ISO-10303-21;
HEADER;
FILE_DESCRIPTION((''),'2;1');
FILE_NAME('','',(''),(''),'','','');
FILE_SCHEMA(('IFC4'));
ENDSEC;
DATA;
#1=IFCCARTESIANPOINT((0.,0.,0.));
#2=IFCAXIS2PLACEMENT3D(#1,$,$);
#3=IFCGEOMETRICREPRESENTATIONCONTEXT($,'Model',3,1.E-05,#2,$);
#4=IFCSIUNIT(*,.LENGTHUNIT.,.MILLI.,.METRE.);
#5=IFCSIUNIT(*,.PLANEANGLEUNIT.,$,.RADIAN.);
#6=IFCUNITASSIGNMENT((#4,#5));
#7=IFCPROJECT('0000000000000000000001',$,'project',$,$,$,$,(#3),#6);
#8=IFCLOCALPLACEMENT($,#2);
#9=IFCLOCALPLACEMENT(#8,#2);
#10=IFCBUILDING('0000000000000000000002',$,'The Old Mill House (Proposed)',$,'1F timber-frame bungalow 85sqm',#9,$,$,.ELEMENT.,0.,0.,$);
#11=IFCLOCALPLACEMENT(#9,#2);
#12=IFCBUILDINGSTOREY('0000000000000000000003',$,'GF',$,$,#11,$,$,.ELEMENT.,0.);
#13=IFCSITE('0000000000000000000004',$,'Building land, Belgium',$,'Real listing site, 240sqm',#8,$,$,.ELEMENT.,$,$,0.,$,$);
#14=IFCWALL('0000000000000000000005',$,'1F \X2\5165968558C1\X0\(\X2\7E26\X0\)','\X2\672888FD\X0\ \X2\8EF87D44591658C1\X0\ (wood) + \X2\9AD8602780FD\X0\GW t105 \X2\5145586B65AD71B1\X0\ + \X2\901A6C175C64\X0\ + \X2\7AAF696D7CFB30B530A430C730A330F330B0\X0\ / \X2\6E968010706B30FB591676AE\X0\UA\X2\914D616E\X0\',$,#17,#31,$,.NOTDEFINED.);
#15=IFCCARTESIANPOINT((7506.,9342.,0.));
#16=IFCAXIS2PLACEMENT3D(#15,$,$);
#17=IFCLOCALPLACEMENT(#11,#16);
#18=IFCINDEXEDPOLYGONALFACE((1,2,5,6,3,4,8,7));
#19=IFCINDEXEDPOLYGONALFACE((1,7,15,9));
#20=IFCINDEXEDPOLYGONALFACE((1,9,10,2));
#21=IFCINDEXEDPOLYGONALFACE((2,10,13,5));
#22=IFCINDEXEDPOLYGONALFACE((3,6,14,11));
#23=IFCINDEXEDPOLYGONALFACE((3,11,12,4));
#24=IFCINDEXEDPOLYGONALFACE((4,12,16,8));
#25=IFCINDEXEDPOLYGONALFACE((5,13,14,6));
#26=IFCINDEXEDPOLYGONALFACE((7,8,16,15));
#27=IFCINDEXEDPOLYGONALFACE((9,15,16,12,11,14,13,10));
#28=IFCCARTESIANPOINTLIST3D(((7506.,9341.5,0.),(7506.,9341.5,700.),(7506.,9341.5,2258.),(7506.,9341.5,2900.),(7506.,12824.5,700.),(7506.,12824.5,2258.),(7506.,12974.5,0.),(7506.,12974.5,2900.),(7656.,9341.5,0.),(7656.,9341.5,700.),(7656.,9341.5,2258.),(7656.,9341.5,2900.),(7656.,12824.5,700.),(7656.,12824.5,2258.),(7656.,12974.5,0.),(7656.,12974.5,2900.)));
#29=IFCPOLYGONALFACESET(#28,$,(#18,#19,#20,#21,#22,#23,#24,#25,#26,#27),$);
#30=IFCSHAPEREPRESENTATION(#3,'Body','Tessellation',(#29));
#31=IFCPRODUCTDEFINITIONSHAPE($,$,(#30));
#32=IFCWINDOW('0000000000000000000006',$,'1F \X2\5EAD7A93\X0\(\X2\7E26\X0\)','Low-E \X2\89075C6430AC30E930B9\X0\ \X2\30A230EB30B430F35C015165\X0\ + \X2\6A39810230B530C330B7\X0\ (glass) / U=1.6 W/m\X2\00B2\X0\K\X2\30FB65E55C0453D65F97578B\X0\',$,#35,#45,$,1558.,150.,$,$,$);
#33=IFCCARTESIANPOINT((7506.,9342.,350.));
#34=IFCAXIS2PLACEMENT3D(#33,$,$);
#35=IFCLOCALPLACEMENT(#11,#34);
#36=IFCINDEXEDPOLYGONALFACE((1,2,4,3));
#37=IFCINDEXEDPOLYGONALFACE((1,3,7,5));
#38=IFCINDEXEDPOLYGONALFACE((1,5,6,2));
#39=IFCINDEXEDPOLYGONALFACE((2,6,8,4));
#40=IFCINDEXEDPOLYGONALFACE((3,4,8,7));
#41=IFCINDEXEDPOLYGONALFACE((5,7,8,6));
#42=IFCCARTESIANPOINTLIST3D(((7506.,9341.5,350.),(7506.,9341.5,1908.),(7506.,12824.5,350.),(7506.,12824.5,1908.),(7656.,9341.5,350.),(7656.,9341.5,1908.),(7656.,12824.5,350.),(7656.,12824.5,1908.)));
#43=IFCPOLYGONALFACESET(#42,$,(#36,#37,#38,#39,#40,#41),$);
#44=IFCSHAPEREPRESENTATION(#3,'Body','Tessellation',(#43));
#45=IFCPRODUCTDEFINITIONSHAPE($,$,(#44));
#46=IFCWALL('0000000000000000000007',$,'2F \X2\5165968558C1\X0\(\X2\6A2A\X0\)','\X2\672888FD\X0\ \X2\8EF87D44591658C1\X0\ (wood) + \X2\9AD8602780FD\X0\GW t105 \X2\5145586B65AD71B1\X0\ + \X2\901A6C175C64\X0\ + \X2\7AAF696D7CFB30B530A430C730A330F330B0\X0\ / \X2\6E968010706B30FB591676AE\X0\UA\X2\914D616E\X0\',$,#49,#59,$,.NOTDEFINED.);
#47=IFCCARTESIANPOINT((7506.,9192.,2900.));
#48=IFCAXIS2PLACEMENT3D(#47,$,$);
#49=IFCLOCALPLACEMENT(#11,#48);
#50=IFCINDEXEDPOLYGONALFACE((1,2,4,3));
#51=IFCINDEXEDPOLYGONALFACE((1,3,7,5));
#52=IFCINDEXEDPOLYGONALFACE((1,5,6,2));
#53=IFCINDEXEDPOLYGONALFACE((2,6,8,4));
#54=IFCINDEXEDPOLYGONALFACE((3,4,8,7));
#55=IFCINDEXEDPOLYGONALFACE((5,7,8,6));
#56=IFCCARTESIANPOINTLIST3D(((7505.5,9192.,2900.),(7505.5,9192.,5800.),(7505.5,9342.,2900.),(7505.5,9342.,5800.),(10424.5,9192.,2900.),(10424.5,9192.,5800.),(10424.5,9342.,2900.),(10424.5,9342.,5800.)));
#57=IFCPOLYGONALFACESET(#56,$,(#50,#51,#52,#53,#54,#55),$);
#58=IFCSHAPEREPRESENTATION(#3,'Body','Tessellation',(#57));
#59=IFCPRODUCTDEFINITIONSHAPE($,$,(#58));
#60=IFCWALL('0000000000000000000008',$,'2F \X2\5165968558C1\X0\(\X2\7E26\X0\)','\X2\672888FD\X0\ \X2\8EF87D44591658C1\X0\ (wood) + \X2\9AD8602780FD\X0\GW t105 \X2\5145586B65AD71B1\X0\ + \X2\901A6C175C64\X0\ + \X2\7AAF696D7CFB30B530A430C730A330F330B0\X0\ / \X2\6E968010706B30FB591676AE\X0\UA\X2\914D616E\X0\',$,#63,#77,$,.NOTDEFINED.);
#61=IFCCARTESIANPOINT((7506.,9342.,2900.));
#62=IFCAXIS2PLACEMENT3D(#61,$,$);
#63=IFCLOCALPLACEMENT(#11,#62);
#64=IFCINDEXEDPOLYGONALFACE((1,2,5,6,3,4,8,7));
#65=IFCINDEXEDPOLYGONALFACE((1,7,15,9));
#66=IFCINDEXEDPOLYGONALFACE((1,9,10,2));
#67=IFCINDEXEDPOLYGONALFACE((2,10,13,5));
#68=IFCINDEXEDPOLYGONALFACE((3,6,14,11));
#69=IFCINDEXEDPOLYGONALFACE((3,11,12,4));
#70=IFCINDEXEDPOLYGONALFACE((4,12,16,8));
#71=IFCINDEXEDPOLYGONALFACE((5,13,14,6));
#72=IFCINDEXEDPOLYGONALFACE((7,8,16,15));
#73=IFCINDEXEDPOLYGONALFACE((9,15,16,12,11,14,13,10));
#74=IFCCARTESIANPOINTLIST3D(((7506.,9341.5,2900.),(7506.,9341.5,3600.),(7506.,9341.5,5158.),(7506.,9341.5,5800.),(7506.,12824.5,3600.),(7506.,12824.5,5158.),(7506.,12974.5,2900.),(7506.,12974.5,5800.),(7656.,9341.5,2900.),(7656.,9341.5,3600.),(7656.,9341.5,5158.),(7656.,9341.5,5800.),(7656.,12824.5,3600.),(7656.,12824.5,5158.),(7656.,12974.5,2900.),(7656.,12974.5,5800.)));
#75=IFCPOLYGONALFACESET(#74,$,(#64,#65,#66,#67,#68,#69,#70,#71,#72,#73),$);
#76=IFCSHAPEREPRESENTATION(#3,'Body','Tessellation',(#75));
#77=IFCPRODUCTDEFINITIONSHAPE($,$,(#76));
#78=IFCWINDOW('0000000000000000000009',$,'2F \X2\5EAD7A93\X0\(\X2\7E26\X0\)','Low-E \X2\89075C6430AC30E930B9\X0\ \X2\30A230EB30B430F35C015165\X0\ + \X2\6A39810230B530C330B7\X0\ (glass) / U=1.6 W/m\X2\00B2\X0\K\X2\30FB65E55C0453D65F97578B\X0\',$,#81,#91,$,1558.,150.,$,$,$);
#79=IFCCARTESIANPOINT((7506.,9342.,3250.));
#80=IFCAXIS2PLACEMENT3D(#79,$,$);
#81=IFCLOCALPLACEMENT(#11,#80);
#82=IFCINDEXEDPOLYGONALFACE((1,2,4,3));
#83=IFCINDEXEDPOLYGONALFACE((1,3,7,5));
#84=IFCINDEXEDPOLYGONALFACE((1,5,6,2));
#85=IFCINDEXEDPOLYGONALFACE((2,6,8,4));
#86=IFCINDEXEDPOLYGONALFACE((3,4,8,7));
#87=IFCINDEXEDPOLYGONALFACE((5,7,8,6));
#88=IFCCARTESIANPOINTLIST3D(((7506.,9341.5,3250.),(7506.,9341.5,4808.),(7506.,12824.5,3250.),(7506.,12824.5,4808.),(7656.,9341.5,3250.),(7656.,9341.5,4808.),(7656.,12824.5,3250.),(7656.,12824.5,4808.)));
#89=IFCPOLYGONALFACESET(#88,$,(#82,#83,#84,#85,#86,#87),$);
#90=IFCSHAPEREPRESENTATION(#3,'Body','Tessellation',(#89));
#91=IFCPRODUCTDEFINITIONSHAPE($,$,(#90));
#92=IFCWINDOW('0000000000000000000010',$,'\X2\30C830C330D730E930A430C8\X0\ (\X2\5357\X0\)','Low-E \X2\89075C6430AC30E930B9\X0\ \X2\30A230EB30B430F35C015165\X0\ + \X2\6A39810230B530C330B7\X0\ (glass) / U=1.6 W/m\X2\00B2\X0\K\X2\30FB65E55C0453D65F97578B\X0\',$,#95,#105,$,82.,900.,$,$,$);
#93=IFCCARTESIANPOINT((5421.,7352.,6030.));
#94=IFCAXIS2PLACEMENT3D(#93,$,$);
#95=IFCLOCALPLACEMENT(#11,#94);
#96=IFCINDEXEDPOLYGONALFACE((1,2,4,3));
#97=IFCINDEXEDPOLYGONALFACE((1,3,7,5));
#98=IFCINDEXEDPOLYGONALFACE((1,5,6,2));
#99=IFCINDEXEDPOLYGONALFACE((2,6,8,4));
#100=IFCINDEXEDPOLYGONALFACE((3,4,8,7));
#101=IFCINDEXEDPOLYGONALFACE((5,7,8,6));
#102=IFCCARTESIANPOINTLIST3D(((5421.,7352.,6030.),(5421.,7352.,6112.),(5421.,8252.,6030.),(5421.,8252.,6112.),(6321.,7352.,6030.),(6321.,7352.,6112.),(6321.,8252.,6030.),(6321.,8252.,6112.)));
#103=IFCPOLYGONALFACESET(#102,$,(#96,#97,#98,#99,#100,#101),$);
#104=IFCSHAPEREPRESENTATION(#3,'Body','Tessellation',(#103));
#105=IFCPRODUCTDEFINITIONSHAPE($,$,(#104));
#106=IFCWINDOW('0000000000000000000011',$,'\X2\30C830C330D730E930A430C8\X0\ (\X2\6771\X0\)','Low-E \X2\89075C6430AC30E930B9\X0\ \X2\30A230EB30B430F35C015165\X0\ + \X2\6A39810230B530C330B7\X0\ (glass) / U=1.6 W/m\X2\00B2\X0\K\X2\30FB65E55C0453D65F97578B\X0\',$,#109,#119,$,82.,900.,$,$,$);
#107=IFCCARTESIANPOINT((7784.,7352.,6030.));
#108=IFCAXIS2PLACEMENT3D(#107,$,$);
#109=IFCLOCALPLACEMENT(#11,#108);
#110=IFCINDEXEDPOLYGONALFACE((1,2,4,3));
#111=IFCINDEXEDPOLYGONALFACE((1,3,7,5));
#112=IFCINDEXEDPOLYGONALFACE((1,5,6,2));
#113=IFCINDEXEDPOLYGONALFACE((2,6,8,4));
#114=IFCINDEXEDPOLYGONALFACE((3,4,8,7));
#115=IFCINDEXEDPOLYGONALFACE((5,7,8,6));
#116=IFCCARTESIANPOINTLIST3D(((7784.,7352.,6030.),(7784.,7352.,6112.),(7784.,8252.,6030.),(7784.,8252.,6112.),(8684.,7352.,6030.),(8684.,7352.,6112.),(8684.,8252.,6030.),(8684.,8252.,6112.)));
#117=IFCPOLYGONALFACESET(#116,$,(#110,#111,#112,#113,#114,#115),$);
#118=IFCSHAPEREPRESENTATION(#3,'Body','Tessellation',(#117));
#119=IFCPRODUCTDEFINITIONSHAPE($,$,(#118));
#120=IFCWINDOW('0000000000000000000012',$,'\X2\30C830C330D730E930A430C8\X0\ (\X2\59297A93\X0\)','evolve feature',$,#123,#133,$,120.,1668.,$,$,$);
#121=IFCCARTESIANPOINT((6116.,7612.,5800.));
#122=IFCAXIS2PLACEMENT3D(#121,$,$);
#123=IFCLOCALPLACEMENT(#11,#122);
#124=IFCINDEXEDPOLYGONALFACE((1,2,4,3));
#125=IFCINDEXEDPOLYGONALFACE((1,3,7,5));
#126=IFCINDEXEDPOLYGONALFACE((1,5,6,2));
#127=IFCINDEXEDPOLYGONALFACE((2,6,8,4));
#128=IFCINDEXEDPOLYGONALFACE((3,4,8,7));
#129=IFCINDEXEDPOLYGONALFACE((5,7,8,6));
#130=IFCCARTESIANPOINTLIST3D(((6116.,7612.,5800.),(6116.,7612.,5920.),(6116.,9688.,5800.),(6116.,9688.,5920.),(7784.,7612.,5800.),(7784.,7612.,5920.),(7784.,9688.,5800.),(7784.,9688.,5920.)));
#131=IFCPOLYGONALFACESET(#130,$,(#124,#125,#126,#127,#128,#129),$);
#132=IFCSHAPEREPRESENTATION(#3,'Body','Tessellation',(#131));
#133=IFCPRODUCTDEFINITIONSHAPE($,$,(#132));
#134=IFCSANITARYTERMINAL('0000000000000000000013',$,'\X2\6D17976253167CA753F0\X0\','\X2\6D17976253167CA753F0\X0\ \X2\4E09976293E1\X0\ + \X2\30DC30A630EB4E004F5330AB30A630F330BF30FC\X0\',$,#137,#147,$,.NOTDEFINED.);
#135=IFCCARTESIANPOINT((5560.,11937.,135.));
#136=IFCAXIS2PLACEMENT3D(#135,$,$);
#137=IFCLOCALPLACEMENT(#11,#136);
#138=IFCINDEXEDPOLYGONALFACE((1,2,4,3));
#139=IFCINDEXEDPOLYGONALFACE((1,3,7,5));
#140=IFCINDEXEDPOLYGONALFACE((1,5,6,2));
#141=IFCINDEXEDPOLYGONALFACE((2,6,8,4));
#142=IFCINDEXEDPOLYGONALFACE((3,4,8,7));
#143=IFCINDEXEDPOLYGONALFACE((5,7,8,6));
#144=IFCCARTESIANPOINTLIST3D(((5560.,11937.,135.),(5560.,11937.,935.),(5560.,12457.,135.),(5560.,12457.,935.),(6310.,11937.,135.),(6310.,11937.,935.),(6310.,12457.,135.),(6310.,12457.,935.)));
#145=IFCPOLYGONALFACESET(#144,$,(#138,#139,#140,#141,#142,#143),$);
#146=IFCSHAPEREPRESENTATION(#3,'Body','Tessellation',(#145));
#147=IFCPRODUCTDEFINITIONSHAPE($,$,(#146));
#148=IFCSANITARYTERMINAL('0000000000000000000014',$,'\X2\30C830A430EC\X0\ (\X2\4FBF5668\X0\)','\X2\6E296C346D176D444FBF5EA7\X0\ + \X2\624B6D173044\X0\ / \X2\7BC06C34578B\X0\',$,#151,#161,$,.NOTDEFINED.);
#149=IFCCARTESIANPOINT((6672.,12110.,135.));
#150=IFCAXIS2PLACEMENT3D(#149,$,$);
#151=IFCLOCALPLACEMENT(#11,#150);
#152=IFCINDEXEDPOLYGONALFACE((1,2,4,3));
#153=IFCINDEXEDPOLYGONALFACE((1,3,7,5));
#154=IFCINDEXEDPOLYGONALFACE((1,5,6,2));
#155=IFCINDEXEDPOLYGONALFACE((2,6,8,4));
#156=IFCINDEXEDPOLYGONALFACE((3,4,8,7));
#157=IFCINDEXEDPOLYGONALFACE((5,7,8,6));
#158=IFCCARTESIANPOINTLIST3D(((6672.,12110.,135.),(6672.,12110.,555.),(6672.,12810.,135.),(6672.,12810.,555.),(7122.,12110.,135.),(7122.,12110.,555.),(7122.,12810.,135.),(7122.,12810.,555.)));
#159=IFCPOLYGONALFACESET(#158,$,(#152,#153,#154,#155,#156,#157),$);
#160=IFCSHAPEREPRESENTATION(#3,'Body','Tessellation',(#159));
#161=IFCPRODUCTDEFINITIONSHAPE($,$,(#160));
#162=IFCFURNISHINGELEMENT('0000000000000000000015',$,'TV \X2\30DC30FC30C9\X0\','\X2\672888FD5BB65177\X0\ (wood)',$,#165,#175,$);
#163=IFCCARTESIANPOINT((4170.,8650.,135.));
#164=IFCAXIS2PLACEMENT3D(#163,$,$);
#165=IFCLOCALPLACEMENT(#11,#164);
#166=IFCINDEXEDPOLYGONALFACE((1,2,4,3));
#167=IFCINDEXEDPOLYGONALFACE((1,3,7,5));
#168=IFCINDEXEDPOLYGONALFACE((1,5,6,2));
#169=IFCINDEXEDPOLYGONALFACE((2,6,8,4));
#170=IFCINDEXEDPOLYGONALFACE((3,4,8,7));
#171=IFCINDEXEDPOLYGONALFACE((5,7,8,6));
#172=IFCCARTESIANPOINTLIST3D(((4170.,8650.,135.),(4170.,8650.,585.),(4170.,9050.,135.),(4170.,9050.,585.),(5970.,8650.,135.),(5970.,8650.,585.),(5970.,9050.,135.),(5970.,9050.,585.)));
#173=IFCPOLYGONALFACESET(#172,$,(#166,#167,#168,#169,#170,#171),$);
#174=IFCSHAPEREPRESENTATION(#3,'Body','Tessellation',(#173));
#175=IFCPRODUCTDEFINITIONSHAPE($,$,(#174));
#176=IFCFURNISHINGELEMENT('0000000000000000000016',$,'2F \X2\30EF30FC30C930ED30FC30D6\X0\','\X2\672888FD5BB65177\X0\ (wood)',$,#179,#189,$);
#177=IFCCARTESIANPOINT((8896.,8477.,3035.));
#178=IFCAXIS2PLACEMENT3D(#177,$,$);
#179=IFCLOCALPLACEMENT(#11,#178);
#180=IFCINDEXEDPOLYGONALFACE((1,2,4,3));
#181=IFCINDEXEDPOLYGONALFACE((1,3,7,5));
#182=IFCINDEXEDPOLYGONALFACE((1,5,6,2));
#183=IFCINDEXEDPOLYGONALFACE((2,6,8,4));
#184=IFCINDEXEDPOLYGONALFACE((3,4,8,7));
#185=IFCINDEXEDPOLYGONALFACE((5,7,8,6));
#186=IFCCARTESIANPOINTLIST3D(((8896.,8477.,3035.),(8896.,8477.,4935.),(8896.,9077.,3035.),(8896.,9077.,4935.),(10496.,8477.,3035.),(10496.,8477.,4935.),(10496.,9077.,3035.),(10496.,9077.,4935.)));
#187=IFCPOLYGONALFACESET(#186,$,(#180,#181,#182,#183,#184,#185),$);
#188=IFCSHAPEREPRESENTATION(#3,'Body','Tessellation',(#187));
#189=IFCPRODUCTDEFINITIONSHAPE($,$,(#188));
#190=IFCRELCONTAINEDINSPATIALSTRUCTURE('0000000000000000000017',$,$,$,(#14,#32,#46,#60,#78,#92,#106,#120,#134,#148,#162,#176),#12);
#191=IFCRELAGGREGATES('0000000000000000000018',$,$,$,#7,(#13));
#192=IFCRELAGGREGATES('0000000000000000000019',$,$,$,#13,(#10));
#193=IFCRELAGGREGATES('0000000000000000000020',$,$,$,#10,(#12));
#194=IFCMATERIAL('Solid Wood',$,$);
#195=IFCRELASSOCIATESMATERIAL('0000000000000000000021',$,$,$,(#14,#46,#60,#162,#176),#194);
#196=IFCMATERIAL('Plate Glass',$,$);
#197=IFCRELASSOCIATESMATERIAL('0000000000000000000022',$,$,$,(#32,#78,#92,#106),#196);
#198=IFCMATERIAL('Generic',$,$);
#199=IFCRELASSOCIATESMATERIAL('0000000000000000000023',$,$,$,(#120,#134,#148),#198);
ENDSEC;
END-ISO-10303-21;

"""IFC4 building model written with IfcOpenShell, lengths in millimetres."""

from ifc_helpers import new_model, si_unit, frame, frame_2d, origin, place, context, project, spatial, rectangle, extrude, material, element, fill, save


model = new_model("IFC4")

# Units and contexts
model_context = context("Model", 3, precision=1e-05, world=origin())
ifc_project = project(units=[si_unit("LENGTHUNIT", "METRE", prefix="MILLI"), si_unit("PLANEANGLEUNIT", "RADIAN")], contexts=[model_context])

# Site, building, storey
site_placement = place(None, origin())
site = spatial("IfcSite", under=ifc_project, at=site_placement, Name="Building land, Belgium", ObjectType="Real listing site, 240sqm", CompositionType="ELEMENT", RefElevation=0.0)
building_placement = place(site_placement, origin())
building = spatial("IfcBuilding", under=site, at=building_placement, Name="The Old Mill House (Proposed)", ObjectType="1F timber-frame bungalow 85sqm", CompositionType="ELEMENT", ElevationOfRefHeight=0.0, ElevationOfTerrain=0.0)
storey_placement = place(building_placement, origin())
storey = spatial("IfcBuildingStorey", under=building, at=storey_placement, Name="GF", CompositionType="ELEMENT", Elevation=0.0)

# Shared definitions
ifc_material_1 = material(Name="Solid Wood")

# Wall, opening, window
wall_1_placement = place(storey_placement, frame((7506.0, 9342.0, 0.0)))
wall_1 = element("IfcWall", 1, at=wall_1_placement, inside=storey, material=ifc_material_1, Name="1F 入隅壁(縦)", Description="木製 軸組外壁 (wood) + 高性能GW t105 充填断熱 + 通気層 + 窯業系サイディング / 準耐火・外皮UA配慮", PredefinedType="NOTDEFINED", context=model_context, shape_type="SweptSolid", body=[
    extrude(rectangle(XDim=150.0, YDim=3633.0, at=frame_2d((75.0, 1816.0))), frame((7506.0, 9342.0, 0.0)), (0.0, 0.0, 1.0), 2900.0),
])
opening_1_placement = place(storey_placement, frame((7506.0, 9342.0, 350.0)))
opening_1 = element("IfcOpeningElement", 2, at=opening_1_placement, cuts=wall_1, PredefinedType="NOTDEFINED", context=model_context, shape_type="SweptSolid", body=[
    extrude(rectangle(XDim=150.0, YDim=3483.0, at=frame_2d((75.0, 1741.0))), frame((7506.0, 9342.0, 350.0)), (0.0, 0.0, 1.0), 1558.0),
])
ifc_material_2 = material(Name="Plate Glass")
window_1_placement = place(storey_placement, frame((7506.0, 9342.0, 350.0)))
window_1 = element("IfcWindow", 3, at=window_1_placement, inside=storey, material=ifc_material_2, Name="1F 庭窓(縦)", Description="Low-E 複層ガラス アルゴン封入 + 樹脂サッシ (glass) / U=1.6 W/m²K・日射取得型", OverallHeight=1558.0, OverallWidth=150.0, context=model_context, shape_type="SweptSolid", body=[
    extrude(rectangle(XDim=150.0, YDim=3483.0, at=frame_2d((75.0, 1741.0))), frame((7506.0, 9342.0, 350.0)), (0.0, 0.0, 1.0), 1558.0),
])
fill(opening_1, window_1)

# Wall
wall_2_placement = place(storey_placement, frame((7506.0, 9192.0, 2900.0)))
element("IfcWall", 4, at=wall_2_placement, inside=storey, material=ifc_material_1, Name="2F 入隅壁(横)", Description="木製 軸組外壁 (wood) + 高性能GW t105 充填断熱 + 通気層 + 窯業系サイディング / 準耐火・外皮UA配慮", PredefinedType="NOTDEFINED", context=model_context, shape_type="SweptSolid", body=[
    extrude(rectangle(XDim=2919.0, YDim=150.0, at=frame_2d((1459.0, 75.0))), frame((7506.0, 9192.0, 2900.0)), (0.0, 0.0, 1.0), 2900.0),
])

# Wall, opening, window
wall_3_placement = place(storey_placement, frame((7506.0, 9342.0, 2900.0)))
wall_3 = element("IfcWall", 5, at=wall_3_placement, inside=storey, material=ifc_material_1, Name="2F 入隅壁(縦)", Description="木製 軸組外壁 (wood) + 高性能GW t105 充填断熱 + 通気層 + 窯業系サイディング / 準耐火・外皮UA配慮", PredefinedType="NOTDEFINED", context=model_context, shape_type="SweptSolid", body=[
    extrude(rectangle(XDim=150.0, YDim=3633.0, at=frame_2d((75.0, 1816.0))), frame((7506.0, 9342.0, 2900.0)), (0.0, 0.0, 1.0), 2900.0),
])
opening_2_placement = place(storey_placement, frame((7506.0, 9342.0, 3250.0)))
opening_2 = element("IfcOpeningElement", 6, at=opening_2_placement, cuts=wall_3, PredefinedType="NOTDEFINED", context=model_context, shape_type="SweptSolid", body=[
    extrude(rectangle(XDim=150.0, YDim=3483.0, at=frame_2d((75.0, 1741.0))), frame((7506.0, 9342.0, 3250.0)), (0.0, 0.0, 1.0), 1558.0),
])
window_2_placement = place(storey_placement, frame((7506.0, 9342.0, 3250.0)))
window_2 = element("IfcWindow", 7, at=window_2_placement, inside=storey, material=ifc_material_2, Name="2F 庭窓(縦)", Description="Low-E 複層ガラス アルゴン封入 + 樹脂サッシ (glass) / U=1.6 W/m²K・日射取得型", OverallHeight=1558.0, OverallWidth=150.0, context=model_context, shape_type="SweptSolid", body=[
    extrude(rectangle(XDim=150.0, YDim=3483.0, at=frame_2d((75.0, 1741.0))), frame((7506.0, 9342.0, 3250.0)), (0.0, 0.0, 1.0), 1558.0),
])
fill(opening_2, window_2)

# Windows
window_3_placement = place(storey_placement, frame((5421.0, 7352.0, 6030.0)))
element("IfcWindow", 8, at=window_3_placement, inside=storey, material=ifc_material_2, Name="トップライト (南)", Description="Low-E 複層ガラス アルゴン封入 + 樹脂サッシ (glass) / U=1.6 W/m²K・日射取得型", OverallHeight=82.0, OverallWidth=900.0, context=model_context, shape_type="SweptSolid", body=[
    extrude(rectangle(XDim=900.0, YDim=900.0, at=frame_2d((450.0, 450.0))), frame((5421.0, 7352.0, 6030.0)), (0.0, 0.0, 1.0), 82.0),
])
window_4_placement = place(storey_placement, frame((7784.0, 7352.0, 6030.0)))
element("IfcWindow", 9, at=window_4_placement, inside=storey, material=ifc_material_2, Name="トップライト (東)", Description="Low-E 複層ガラス アルゴン封入 + 樹脂サッシ (glass) / U=1.6 W/m²K・日射取得型", OverallHeight=82.0, OverallWidth=900.0, context=model_context, shape_type="SweptSolid", body=[
    extrude(rectangle(XDim=900.0, YDim=900.0, at=frame_2d((450.0, 450.0))), frame((7784.0, 7352.0, 6030.0)), (0.0, 0.0, 1.0), 82.0),
])
ifc_material_3 = material(Name="Generic")
window_5_placement = place(storey_placement, frame((6116.0, 7612.0, 5800.0)))
element("IfcWindow", 10, at=window_5_placement, inside=storey, material=ifc_material_3, Name="トップライト (天窓)", Description="evolve feature", OverallHeight=120.0, OverallWidth=1668.0, context=model_context, shape_type="SweptSolid", body=[
    extrude(rectangle(XDim=1668.0, YDim=2076.0, at=frame_2d((834.0, 1038.0))), frame((6116.0, 7612.0, 5800.0)), (0.0, 0.0, 1.0), 120.0),
])

# Sanitary terminals
sanitary_terminal_1_placement = place(storey_placement, frame((5560.0, 11937.0, 135.0)))
element("IfcSanitaryTerminal", 11, at=sanitary_terminal_1_placement, inside=storey, material=ifc_material_3, Name="洗面化粧台", Description="洗面化粧台 三面鏡 + ボウル一体カウンター", PredefinedType="NOTDEFINED", context=model_context, shape_type="SweptSolid", body=[
    extrude(rectangle(XDim=750.0, YDim=520.0, at=frame_2d((375.0, 260.0))), frame((5560.0, 11937.0, 135.0)), (0.0, 0.0, 1.0), 800.0),
])
sanitary_terminal_2_placement = place(storey_placement, frame((6672.0, 12110.0, 135.0)))
element("IfcSanitaryTerminal", 12, at=sanitary_terminal_2_placement, inside=storey, material=ifc_material_3, Name="トイレ (便器)", Description="温水洗浄便座 + 手洗い / 節水型", PredefinedType="NOTDEFINED", context=model_context, shape_type="SweptSolid", body=[
    extrude(rectangle(XDim=450.0, YDim=700.0, at=frame_2d((225.0, 350.0))), frame((6672.0, 12110.0, 135.0)), (0.0, 0.0, 1.0), 420.0),
])

# Furnishing elements
furnishing_1_placement = place(storey_placement, frame((4170.0, 8650.0, 135.0)))
element("IfcFurnishingElement", 13, at=furnishing_1_placement, inside=storey, material=ifc_material_1, Name="TV ボード", Description="木製家具 (wood)", context=model_context, shape_type="SweptSolid", body=[
    extrude(rectangle(XDim=1800.0, YDim=400.0, at=frame_2d((900.0, 200.0))), frame((4170.0, 8650.0, 135.0)), (0.0, 0.0, 1.0), 450.0),
])
furnishing_2_placement = place(storey_placement, frame((8896.0, 8477.0, 3035.0)))
element("IfcFurnishingElement", 14, at=furnishing_2_placement, inside=storey, material=ifc_material_1, Name="2F ワードローブ", Description="木製家具 (wood)", context=model_context, shape_type="SweptSolid", body=[
    extrude(rectangle(XDim=1600.0, YDim=600.0, at=frame_2d((800.0, 300.0))), frame((8896.0, 8477.0, 3035.0)), (0.0, 0.0, 1.0), 1900.0),
])

save(model, "model.ifc")
